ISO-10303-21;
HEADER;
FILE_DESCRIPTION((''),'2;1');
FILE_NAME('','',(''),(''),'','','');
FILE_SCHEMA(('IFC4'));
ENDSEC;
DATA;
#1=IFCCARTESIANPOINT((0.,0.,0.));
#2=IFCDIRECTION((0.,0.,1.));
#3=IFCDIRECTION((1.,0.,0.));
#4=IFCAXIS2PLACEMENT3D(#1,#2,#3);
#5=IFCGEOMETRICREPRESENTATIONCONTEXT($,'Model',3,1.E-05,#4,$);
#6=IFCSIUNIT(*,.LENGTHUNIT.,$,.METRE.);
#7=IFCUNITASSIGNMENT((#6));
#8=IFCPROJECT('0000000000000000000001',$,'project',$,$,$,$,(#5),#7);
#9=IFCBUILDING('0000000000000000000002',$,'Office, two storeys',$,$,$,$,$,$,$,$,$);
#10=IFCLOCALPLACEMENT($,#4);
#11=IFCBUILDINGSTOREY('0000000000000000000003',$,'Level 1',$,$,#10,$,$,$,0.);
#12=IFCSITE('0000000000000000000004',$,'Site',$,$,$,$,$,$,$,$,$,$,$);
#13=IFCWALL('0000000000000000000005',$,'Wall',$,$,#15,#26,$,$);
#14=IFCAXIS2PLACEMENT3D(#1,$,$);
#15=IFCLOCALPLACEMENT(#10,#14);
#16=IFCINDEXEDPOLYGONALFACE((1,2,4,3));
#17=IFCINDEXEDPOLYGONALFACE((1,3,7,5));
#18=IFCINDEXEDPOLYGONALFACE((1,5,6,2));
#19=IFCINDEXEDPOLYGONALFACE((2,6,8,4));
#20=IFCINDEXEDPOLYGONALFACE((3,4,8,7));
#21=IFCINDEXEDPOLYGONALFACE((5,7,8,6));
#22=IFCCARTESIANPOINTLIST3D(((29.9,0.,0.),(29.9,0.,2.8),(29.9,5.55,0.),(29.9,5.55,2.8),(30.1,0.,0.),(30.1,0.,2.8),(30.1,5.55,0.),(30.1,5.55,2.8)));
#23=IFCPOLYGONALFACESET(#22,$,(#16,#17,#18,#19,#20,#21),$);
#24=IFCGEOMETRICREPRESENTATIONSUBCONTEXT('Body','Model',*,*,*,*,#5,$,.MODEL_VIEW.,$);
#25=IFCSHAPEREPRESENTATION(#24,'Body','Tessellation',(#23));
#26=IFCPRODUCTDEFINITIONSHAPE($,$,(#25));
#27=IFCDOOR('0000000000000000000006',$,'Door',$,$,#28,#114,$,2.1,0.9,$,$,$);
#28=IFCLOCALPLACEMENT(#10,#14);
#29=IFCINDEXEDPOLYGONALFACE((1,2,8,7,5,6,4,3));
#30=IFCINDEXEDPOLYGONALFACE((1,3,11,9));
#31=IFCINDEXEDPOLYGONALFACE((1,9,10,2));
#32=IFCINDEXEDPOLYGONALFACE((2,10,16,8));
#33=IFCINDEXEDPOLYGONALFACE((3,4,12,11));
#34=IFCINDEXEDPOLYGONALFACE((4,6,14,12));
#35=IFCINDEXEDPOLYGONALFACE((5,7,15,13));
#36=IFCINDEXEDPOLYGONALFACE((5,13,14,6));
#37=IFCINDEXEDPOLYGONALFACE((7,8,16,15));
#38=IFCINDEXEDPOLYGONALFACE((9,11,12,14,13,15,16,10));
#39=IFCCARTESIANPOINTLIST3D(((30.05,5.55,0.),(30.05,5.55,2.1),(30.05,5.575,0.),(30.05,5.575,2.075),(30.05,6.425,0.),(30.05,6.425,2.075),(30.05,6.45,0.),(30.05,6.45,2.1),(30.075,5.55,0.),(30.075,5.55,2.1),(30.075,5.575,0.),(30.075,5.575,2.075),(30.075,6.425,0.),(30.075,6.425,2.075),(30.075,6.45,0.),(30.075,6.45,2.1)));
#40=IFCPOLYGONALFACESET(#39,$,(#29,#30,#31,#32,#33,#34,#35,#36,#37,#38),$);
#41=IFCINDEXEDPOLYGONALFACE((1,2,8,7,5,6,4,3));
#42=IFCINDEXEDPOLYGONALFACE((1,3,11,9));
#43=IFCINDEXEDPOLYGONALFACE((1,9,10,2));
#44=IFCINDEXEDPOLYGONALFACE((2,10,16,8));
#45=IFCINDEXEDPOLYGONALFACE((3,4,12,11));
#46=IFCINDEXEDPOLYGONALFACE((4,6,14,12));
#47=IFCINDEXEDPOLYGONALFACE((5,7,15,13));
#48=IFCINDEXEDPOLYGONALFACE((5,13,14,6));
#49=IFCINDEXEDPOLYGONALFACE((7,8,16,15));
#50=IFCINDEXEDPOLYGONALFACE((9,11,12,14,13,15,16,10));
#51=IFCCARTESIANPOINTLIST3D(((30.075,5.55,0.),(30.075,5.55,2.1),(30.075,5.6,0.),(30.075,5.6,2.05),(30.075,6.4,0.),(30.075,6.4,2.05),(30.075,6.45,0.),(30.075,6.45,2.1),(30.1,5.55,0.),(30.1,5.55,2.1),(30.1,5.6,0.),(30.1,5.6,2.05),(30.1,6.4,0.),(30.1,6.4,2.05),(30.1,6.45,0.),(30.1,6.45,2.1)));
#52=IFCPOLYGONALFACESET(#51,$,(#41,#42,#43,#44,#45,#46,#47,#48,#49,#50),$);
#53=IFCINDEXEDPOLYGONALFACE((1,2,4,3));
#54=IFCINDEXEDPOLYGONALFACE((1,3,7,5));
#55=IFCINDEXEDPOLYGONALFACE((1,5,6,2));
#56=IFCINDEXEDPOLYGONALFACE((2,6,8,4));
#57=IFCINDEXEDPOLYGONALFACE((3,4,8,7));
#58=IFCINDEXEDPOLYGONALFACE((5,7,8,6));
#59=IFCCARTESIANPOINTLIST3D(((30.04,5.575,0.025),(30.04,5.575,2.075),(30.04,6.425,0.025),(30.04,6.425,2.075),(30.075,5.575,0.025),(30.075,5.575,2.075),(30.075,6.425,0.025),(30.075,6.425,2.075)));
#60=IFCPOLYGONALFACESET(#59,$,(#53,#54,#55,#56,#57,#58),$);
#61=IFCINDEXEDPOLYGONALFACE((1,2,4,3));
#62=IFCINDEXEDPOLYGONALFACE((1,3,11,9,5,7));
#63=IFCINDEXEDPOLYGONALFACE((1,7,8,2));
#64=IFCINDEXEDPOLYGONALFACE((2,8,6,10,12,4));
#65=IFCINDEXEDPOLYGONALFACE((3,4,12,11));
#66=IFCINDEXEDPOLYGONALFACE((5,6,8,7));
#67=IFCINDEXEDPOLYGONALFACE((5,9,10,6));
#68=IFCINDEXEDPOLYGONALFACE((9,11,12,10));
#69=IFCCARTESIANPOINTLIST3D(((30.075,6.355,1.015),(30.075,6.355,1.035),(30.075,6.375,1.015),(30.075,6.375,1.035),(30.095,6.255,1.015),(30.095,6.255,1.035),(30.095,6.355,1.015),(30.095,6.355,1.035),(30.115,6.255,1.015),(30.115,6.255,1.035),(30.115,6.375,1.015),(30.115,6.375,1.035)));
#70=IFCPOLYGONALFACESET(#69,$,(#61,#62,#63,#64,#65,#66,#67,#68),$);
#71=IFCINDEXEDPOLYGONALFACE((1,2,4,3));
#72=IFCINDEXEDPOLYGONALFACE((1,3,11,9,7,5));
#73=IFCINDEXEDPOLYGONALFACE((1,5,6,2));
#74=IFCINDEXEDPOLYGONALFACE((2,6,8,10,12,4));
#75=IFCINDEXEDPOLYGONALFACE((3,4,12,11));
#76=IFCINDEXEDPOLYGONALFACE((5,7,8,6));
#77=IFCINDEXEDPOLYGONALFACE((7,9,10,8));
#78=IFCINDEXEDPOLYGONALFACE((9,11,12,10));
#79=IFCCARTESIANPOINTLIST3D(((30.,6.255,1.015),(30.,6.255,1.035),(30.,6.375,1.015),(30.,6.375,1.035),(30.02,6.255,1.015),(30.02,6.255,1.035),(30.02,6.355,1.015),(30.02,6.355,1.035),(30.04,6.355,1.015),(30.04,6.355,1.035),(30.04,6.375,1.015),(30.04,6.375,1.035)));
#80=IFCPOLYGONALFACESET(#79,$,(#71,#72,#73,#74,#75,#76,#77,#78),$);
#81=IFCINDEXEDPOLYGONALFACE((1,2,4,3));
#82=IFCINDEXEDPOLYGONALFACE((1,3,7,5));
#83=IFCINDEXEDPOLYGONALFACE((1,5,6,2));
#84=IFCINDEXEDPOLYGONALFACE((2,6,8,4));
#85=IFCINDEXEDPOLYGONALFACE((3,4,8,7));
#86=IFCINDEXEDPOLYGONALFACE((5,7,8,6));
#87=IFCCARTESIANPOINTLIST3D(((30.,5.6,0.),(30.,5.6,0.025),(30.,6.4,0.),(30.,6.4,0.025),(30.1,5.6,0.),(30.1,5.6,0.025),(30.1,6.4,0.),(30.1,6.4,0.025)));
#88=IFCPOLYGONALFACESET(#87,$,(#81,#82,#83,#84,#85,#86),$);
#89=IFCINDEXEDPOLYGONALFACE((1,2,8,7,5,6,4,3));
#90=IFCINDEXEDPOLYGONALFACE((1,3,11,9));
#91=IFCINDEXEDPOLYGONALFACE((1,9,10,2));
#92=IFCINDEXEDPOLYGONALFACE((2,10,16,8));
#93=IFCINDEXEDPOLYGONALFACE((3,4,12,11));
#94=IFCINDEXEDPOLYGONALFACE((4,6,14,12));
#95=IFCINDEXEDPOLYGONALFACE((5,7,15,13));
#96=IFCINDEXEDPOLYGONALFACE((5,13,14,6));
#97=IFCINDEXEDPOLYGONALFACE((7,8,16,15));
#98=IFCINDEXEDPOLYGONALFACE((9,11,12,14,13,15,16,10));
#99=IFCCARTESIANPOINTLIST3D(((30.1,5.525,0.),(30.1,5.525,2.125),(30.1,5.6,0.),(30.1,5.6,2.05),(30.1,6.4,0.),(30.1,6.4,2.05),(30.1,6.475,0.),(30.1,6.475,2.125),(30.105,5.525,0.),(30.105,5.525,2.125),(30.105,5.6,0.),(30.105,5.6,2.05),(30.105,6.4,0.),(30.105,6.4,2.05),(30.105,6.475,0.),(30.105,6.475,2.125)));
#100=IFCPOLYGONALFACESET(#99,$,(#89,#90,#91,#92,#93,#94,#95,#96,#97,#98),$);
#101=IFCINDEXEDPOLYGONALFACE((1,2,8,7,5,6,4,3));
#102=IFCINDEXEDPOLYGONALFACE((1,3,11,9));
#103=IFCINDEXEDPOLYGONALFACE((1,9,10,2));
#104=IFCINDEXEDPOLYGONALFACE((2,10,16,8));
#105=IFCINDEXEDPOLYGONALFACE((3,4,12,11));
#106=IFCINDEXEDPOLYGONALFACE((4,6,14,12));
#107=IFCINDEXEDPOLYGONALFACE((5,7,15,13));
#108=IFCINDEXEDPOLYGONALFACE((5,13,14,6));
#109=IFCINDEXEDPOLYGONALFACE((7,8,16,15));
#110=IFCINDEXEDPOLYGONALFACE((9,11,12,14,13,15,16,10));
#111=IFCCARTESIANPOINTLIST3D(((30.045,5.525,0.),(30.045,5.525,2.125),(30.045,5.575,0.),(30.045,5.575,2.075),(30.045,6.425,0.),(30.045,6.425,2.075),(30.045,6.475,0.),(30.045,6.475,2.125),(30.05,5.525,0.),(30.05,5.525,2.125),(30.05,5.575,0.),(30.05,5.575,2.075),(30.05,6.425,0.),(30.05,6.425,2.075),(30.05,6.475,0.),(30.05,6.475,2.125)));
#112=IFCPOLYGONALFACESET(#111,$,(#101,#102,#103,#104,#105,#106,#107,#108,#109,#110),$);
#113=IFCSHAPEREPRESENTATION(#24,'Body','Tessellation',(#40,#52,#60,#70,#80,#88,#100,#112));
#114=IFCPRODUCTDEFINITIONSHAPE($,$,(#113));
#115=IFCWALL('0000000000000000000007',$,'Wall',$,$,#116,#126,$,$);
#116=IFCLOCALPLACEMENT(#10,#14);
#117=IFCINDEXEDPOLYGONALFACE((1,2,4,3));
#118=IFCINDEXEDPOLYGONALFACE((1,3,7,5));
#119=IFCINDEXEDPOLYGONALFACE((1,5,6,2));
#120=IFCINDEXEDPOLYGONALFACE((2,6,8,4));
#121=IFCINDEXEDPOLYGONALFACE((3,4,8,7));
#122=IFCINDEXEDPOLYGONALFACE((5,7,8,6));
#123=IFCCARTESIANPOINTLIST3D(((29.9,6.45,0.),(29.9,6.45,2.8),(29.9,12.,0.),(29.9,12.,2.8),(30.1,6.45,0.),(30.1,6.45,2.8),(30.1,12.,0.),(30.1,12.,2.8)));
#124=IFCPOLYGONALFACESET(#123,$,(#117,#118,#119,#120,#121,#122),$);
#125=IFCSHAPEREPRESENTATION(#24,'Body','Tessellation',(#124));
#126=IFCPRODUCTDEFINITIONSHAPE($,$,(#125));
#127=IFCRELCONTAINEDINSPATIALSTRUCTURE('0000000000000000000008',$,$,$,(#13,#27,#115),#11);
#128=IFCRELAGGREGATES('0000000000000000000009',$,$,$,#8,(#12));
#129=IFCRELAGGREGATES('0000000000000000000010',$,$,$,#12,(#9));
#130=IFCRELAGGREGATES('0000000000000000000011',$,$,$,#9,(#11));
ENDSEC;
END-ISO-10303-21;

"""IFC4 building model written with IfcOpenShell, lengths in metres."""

from ifc_helpers import new_model, si_unit, frame, origin_with_axes, place, context, subcontext, project, spatial, line, indexed_curve, outline, extrude, element, save


model = new_model("IFC4")

# Units and contexts
model_context = context("Model", 3, precision=1e-05, world=origin_with_axes())
body_context = subcontext(model_context, "Body", "Model", "MODEL_VIEW")
ifc_project = project(units=[si_unit("LENGTHUNIT", "METRE")], contexts=[model_context])

# Site, building, storey
site = spatial("IfcSite", under=ifc_project, Name="Site")
building = spatial("IfcBuilding", under=site, Name="Office, two storeys")
storey_placement = place(None, origin_with_axes())
storey = spatial("IfcBuildingStorey", under=building, at=storey_placement, Name="Level 1", Elevation=0.0)

# Wall
wall_1_placement = place(storey_placement, frame((30.0, 0.0, 0.0), z_axis=(0.0, 0.0, 1.0), x_axis=(0.0, 1.0, 0.0)))
element("IfcWall", 1, at=wall_1_placement, inside=storey, Name="Wall", context=body_context, shape_type="SweptSolid", body=[
    extrude(outline(indexed_curve([(0.0, 0.0), (0.0, 0.2), (5.55, 0.2), (5.55, 0.0), (0.0, 0.0)], self_intersect=False)), frame((0.0, -0.1, 0.0), z_axis=(0.0, 0.0, 1.0), x_axis=(1.0, 0.0, 0.0)), (0.0, 0.0, 1.0), 2.8),
])

# Door
door_1_placement = place(storey_placement, frame((30.1, 5.55, 0.0), z_axis=(0.0, 0.0, 1.0), x_axis=(0.0, 1.0, 0.0)))
element("IfcDoor", 2, at=door_1_placement, inside=storey, Name="Door", OverallHeight=2.1, OverallWidth=0.9, context=body_context, shape_type="SweptSolid", body=[
    extrude(outline(indexed_curve([(0.0, 0.0), (0.0, 2.1), (0.9, 2.1), (0.9, 0.0), (0.875, 0.0), (0.875, 2.075), (0.025, 2.075), (0.025, 0.0)], segments=[line(1, 2, 3, 4, 5, 6, 7, 8, 1)])), frame((0.0, 0.025, 0.0), z_axis=(0.0, -1.0, 0.0), x_axis=(1.0, 0.0, 0.0)), (0.0, 0.0, -1.0), 0.025),
    extrude(outline(indexed_curve([(0.0, 0.0), (0.0, 2.1), (0.9, 2.1), (0.9, 0.0), (0.85, 0.0), (0.85, 2.05), (0.05, 2.05), (0.05, 0.0)], segments=[line(1, 2, 3, 4, 5, 6, 7, 8, 1)])), frame((0.0, 0.0, 0.0), z_axis=(0.0, -1.0, 0.0), x_axis=(1.0, 0.0, 0.0)), (0.0, 0.0, -1.0), 0.025),
    extrude(outline(indexed_curve([(0.0, 0.0), (0.85, 0.0), (0.85, 0.035), (0.0, 0.035)], segments=[line(1, 2, 3, 4, 1)])), frame((0.025, 0.025, 0.025), z_axis=(0.0, 0.0, 1.0), x_axis=(1.0, 0.0, 0.0)), (0.0, 0.0, 1.0), 2.05),
    extrude(outline(indexed_curve([(0.0, 0.0), (0.0, -0.04), (-0.12, -0.04), (-0.12, -0.02), (-0.02, -0.02), (-0.02, 0.0)], segments=[line(1, 2, 3, 4, 5, 6, 1)])), frame((0.825, 0.025, 1.015), z_axis=(0.0, 0.0, 1.0), x_axis=(1.0, 0.0, 0.0)), (0.0, 0.0, 1.0), 0.02),
    extrude(outline(indexed_curve([(0.0, 0.0), (0.0, 0.04), (-0.12, 0.04), (-0.12, 0.02), (-0.02, 0.02), (-0.02, 0.0)], segments=[line(1, 2, 3, 4, 5, 6, 1)])), frame((0.825, 0.06, 1.015), z_axis=(0.0, 0.0, 1.0), x_axis=(1.0, 0.0, 0.0)), (0.0, 0.0, 1.0), 0.02),
    extrude(outline(indexed_curve([(0.0, 0.0), (0.8, 0.0), (0.8, 0.1), (0.0, 0.1)], segments=[line(1, 2, 3, 4, 1)])), frame((0.05, 0.0, 0.0), z_axis=(0.0, 0.0, 1.0), x_axis=(1.0, 0.0, 0.0)), (0.0, 0.0, 1.0), 0.025),
    extrude(outline(indexed_curve([(0.0, 0.0), (0.0, 2.125), (0.95, 2.125), (0.95, 0.0), (0.875, 0.0), (0.875, 2.05), (0.075, 2.05), (0.075, 0.0)], segments=[line(1, 2, 3, 4, 5, 6, 7, 8, 1)])), frame((-0.025, -0.005, 0.0), z_axis=(0.0, -1.0, 0.0), x_axis=(1.0, 0.0, 0.0)), (0.0, 0.0, -1.0), 0.005),
    extrude(outline(indexed_curve([(0.0, 0.0), (0.0, 2.125), (0.95, 2.125), (0.95, 0.0), (0.9, 0.0), (0.9, 2.075), (0.05, 2.075), (0.05, 0.0)], segments=[line(1, 2, 3, 4, 5, 6, 7, 8, 1)])), frame((-0.025, 0.05, 0.0), z_axis=(0.0, -1.0, 0.0), x_axis=(1.0, 0.0, 0.0)), (0.0, 0.0, -1.0), 0.005),
])

# Wall
wall_2_placement = place(storey_placement, frame((30.0, 6.45, 0.0), z_axis=(0.0, 0.0, 1.0), x_axis=(0.0, 1.0, 0.0)))
element("IfcWall", 3, at=wall_2_placement, inside=storey, Name="Wall", context=body_context, shape_type="SweptSolid", body=[
    extrude(outline(indexed_curve([(0.0, 0.0), (0.0, 0.2), (5.55, 0.2), (5.55, 0.0), (0.0, 0.0)], self_intersect=False)), frame((0.0, -0.1, 0.0), z_axis=(0.0, 0.0, 1.0), x_axis=(1.0, 0.0, 0.0)), (0.0, 0.0, 1.0), 2.8),
])

save(model, "model.ifc")
